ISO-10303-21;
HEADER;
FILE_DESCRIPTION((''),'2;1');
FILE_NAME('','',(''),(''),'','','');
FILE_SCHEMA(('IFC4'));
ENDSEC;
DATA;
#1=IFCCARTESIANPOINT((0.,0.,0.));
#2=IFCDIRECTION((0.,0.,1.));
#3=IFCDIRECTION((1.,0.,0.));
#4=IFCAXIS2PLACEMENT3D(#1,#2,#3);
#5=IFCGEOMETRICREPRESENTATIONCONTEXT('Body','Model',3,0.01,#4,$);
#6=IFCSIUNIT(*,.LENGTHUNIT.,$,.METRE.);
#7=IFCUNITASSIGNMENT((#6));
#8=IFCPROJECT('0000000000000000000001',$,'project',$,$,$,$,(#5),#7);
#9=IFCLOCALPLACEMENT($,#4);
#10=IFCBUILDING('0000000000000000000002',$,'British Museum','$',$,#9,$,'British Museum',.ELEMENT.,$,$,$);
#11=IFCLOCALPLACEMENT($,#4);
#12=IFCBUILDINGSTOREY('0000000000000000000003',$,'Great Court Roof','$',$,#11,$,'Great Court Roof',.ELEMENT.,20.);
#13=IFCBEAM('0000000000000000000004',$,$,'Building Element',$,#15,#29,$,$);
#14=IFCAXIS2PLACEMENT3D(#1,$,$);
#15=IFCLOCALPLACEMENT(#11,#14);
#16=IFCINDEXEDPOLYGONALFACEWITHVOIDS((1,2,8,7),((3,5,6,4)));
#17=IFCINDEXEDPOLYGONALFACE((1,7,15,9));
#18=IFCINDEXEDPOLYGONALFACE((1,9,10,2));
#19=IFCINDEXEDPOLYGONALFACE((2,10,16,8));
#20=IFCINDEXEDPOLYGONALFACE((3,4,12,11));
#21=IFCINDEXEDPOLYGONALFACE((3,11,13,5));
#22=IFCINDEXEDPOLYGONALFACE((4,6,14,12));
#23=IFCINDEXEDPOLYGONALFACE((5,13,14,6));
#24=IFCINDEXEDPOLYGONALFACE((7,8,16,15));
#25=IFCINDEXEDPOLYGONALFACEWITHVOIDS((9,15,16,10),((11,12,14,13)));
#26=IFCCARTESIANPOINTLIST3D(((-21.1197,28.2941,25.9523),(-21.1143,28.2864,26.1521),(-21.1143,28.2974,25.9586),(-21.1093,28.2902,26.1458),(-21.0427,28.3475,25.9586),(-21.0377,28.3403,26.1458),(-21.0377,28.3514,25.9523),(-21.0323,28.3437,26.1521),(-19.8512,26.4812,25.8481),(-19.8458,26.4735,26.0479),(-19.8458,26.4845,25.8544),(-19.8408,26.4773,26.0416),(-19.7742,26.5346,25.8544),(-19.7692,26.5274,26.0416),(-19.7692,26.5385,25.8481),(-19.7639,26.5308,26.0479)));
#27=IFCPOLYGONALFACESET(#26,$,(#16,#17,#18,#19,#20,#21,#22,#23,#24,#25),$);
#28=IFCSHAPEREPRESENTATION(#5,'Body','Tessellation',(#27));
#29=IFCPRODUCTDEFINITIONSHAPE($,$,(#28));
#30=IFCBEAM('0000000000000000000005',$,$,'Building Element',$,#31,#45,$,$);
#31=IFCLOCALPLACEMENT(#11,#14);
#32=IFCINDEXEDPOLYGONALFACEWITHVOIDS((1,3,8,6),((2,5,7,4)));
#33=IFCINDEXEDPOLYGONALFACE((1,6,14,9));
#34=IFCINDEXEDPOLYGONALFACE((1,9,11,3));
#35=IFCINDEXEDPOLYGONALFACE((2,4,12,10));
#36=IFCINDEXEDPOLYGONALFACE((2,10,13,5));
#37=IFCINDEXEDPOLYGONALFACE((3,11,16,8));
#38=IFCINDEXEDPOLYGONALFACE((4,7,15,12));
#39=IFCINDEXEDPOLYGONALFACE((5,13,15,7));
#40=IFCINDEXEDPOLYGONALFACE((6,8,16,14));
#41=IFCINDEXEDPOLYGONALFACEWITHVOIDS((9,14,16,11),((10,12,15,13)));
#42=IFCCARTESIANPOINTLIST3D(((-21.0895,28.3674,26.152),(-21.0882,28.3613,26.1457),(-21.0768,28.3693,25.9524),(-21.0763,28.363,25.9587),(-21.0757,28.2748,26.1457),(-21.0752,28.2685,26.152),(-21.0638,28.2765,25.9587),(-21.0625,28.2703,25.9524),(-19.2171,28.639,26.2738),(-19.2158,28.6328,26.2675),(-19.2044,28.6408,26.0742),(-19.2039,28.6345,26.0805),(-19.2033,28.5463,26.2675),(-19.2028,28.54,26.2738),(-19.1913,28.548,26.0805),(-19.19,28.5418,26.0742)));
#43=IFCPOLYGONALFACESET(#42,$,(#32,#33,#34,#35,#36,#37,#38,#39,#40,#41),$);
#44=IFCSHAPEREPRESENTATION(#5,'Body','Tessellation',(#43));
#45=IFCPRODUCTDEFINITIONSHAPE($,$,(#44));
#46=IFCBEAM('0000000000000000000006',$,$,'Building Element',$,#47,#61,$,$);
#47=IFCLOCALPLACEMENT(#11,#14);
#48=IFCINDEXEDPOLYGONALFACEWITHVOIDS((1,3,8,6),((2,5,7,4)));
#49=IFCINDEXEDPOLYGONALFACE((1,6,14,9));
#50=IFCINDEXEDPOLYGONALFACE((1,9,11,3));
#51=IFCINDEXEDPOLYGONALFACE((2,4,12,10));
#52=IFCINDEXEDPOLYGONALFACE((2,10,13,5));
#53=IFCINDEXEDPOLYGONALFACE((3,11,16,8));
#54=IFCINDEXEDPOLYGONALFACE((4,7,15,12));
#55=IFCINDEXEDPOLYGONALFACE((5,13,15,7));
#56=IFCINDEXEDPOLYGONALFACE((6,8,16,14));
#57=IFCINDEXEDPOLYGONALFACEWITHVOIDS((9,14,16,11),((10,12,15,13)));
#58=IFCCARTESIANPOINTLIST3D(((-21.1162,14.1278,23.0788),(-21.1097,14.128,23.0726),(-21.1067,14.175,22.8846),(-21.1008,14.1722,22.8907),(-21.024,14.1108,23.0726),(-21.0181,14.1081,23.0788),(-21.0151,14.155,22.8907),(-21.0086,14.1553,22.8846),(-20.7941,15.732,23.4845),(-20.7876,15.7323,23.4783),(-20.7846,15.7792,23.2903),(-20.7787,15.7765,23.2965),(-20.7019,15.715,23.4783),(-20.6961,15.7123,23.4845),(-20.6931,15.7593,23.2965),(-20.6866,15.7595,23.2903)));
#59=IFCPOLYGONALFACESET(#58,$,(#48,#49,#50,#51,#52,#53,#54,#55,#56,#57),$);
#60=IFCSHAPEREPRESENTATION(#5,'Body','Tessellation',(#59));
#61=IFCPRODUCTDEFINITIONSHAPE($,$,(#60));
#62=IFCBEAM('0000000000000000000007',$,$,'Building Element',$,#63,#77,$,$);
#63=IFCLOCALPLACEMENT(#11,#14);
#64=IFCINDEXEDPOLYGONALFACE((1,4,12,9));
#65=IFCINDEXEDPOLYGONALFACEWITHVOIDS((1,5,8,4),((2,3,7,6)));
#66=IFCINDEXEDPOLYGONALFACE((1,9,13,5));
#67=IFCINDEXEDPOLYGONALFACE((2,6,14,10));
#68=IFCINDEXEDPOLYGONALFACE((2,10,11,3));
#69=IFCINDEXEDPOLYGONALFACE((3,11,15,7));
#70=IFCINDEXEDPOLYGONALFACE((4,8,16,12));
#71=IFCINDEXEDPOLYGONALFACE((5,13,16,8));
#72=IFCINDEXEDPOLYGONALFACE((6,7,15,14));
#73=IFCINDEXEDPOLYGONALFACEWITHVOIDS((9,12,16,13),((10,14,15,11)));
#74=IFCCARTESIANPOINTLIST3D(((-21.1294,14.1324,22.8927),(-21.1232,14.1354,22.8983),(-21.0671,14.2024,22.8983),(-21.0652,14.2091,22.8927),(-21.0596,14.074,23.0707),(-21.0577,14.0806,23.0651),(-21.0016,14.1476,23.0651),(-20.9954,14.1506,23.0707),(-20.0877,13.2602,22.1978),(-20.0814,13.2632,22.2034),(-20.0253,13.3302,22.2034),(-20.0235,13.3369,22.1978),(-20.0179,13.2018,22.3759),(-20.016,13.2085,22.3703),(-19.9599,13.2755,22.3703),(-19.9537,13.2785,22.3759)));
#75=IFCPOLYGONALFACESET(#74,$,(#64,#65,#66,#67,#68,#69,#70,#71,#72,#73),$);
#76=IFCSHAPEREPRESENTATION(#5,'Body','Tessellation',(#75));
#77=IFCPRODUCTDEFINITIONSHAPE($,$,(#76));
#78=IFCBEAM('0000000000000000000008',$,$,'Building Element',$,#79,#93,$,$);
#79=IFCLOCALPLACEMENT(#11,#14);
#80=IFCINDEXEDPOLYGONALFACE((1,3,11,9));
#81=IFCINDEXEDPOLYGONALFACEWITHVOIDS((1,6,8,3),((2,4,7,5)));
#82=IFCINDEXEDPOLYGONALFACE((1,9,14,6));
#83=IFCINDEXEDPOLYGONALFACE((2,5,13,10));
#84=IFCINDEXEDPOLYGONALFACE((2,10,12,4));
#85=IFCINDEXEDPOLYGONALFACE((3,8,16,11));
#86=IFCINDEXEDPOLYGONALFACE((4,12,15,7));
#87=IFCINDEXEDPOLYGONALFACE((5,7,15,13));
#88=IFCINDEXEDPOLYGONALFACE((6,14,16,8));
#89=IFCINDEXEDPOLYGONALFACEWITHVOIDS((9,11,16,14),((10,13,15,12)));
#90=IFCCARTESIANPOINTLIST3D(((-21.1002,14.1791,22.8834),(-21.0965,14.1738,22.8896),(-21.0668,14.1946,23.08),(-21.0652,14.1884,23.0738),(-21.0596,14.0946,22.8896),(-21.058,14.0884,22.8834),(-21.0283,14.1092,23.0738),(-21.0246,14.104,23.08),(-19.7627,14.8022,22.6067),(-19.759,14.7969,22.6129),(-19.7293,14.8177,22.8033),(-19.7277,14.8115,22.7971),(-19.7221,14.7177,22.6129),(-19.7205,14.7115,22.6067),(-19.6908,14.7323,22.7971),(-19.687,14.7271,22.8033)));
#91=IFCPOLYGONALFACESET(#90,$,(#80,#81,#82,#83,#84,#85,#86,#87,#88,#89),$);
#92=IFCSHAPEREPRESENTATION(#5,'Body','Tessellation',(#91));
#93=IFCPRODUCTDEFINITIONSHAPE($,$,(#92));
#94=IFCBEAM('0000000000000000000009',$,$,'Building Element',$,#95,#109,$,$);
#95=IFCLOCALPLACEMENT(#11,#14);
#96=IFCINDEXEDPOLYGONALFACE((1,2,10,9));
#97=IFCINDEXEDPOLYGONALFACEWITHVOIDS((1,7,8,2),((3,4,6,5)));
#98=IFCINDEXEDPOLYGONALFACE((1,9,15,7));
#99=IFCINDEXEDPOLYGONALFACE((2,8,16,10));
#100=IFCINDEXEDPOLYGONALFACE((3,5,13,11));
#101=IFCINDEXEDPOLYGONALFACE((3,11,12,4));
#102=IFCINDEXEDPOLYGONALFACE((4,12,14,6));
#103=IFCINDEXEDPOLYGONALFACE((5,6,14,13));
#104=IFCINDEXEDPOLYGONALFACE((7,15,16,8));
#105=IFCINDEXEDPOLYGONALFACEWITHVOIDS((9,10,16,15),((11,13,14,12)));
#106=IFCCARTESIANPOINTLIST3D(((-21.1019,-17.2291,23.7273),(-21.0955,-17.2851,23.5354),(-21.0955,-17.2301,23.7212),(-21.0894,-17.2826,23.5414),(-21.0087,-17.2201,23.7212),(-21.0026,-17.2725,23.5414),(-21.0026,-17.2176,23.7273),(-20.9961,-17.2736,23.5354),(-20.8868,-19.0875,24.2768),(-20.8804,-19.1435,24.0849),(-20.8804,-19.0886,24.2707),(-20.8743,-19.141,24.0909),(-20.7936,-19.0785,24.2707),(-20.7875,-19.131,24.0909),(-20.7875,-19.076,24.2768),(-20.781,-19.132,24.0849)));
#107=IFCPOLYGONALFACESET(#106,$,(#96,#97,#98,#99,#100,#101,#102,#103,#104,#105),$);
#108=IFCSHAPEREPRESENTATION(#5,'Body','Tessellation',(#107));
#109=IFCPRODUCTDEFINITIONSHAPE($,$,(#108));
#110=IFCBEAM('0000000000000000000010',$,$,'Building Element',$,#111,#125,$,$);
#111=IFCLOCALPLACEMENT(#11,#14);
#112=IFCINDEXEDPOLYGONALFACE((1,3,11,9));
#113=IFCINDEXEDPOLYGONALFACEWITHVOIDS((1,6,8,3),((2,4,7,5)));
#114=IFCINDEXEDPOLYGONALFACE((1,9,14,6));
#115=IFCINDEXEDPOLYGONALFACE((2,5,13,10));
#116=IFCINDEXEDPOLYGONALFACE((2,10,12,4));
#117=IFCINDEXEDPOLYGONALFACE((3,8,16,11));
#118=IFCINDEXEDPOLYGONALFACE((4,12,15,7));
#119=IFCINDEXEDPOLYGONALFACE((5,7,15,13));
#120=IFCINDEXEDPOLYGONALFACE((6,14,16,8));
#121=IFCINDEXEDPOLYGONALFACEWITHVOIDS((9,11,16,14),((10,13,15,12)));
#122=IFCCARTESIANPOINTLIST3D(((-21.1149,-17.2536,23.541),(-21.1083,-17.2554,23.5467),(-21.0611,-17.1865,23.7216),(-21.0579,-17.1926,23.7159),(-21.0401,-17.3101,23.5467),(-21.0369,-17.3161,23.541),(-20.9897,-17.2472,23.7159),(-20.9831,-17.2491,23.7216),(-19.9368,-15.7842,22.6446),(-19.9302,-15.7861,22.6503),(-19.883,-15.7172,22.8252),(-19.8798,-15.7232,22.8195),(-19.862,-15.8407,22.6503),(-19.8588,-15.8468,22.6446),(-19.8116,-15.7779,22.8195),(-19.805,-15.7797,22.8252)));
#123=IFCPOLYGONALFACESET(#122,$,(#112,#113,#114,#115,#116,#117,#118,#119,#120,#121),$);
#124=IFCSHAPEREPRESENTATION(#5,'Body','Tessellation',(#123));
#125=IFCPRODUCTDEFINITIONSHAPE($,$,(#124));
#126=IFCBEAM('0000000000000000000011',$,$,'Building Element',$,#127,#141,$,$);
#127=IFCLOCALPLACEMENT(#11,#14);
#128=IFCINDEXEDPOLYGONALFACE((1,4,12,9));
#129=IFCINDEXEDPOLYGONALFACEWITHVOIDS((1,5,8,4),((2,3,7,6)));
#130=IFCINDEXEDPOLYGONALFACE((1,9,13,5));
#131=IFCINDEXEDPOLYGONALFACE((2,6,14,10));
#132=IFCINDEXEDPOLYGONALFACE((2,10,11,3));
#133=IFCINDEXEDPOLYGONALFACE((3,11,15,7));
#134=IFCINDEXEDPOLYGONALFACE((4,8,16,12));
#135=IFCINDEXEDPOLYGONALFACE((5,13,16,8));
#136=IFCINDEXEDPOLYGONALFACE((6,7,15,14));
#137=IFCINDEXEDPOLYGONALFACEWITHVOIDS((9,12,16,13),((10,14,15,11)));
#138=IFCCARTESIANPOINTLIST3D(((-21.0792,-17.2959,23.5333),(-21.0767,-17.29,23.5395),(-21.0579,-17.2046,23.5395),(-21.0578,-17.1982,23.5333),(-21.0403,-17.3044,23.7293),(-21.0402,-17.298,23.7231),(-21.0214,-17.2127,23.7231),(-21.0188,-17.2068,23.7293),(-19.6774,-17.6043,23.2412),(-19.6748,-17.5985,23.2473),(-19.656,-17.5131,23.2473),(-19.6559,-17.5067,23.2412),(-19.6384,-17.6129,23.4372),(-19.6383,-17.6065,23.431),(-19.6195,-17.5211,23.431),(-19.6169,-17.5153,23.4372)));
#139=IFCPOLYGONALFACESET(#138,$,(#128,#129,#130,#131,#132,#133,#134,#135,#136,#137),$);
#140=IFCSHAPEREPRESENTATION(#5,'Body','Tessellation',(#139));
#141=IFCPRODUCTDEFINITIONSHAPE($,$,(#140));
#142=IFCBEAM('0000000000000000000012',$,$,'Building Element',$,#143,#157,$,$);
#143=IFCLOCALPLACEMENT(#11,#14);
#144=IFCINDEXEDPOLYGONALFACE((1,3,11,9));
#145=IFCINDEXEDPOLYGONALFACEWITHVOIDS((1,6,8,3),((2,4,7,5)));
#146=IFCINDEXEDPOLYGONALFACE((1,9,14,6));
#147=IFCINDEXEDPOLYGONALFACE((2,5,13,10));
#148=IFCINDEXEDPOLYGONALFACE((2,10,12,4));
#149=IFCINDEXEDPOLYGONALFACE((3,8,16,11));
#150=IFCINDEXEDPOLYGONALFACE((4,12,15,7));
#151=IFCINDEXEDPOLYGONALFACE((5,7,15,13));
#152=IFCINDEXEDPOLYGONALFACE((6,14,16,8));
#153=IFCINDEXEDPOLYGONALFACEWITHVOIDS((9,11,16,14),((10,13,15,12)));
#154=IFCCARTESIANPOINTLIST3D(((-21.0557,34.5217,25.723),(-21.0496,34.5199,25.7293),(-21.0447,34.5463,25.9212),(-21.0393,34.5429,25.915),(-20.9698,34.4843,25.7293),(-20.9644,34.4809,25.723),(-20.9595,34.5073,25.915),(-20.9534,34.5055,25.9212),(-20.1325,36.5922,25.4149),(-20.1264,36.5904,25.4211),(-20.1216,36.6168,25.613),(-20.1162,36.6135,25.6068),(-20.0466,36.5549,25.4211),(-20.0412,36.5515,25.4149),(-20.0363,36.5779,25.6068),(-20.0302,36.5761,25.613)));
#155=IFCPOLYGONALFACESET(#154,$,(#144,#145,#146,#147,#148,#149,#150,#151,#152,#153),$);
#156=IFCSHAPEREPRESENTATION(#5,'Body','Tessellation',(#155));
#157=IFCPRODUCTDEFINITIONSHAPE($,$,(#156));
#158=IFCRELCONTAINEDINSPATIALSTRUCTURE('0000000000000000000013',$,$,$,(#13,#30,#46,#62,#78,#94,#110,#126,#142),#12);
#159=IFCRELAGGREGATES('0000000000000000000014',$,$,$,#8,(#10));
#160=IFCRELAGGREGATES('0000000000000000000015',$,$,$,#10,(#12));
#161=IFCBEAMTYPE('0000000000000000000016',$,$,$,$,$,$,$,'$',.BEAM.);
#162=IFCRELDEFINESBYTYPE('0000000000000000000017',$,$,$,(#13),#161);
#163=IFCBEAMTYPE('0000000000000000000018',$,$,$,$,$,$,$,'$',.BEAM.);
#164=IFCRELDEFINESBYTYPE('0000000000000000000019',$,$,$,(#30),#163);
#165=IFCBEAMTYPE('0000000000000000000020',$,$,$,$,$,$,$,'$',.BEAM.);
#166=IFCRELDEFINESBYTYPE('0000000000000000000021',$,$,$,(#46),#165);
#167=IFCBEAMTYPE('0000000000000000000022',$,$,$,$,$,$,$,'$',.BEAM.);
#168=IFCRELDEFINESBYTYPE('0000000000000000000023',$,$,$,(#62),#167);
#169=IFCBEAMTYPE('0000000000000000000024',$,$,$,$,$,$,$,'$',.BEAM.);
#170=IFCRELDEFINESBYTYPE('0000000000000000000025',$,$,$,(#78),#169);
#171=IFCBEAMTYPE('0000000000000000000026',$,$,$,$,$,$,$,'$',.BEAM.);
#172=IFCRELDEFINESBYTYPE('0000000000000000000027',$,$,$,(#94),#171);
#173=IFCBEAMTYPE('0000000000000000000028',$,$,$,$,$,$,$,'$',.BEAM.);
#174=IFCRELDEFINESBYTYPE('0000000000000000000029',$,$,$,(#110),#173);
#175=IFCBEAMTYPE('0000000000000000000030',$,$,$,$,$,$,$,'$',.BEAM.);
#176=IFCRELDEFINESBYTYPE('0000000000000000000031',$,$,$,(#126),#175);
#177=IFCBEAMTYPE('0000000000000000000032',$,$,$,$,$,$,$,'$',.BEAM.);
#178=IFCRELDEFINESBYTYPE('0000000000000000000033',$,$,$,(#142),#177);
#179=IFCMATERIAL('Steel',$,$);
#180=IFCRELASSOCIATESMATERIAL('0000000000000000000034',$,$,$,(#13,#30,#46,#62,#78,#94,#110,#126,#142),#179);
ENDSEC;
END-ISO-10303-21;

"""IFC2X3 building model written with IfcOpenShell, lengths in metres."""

from ifc_helpers import new_model, si_unit, frame, origin_with_axes, origin_2d, place, context, project, spatial, hollow_rectangle, extrude, material, type_object, element, save


model = new_model("IFC2X3")

# Units and contexts
model_context = context("Model", 3, precision=0.01, world=origin_with_axes(), identifier="Body")
ifc_project = project(units=[si_unit("LENGTHUNIT", "METRE")], contexts=[model_context])

# Building, storey
building_placement = place(None, origin_with_axes())
building = spatial("IfcBuilding", under=ifc_project, at=building_placement, Name="British Museum", Description="$", LongName="British Museum", CompositionType="ELEMENT")
storey_placement = place(None, origin_with_axes())
storey = spatial("IfcBuildingStorey", under=building, at=storey_placement, Name="Great Court Roof", Description="$", LongName="Great Court Roof", CompositionType="ELEMENT", Elevation=20.0)

# Beams
ifc_material = material(Name="Steel")
beam_type_1 = type_object("IfcBeamType", ElementType="$", PredefinedType="BEAM")
beam_1_placement = place(None, origin_with_axes())
element("IfcBeam", 1, at=beam_1_placement, inside=storey, type_object=beam_type_1, material=ifc_material, Description="Building Element", context=model_context, shape_type="SweptSolid", body=[
    extrude(hollow_rectangle(XDim=0.1, YDim=0.2, WallThickness=0.0063, InnerFilletRadius=0.0, OuterFilletRadius=0.0, at=origin_2d()), frame((-21.076, 28.3189, 26.0522), z_axis=(0.572659, -0.818443, -0.047046), x_axis=(0.81935, 0.573294, 0.0)), (0.0, 0.0, 1.0), 2.2151),
])
beam_type_2 = type_object("IfcBeamType", ElementType="$", PredefinedType="BEAM")
beam_2_placement = place(None, origin_with_axes())
element("IfcBeam", 2, at=beam_2_placement, inside=storey, type_object=beam_type_2, material=ifc_material, Description="Building Element", context=model_context, shape_type="SweptSolid", body=[
    extrude(hollow_rectangle(XDim=0.1, YDim=0.2, WallThickness=0.0063, InnerFilletRadius=0.0, OuterFilletRadius=0.0, at=origin_2d()), frame((-21.076, 28.3189, 26.0522), z_axis=(0.987603, 0.143218, 0.064257), x_axis=(-0.143514, 0.989648, 0.0)), (0.0, 0.0, 1.0), 1.8959),
])
beam_type_3 = type_object("IfcBeamType", ElementType="$", PredefinedType="BEAM")
beam_3_placement = place(None, origin_with_axes())
element("IfcBeam", 3, at=beam_3_placement, inside=storey, type_object=beam_type_3, material=ifc_material, Description="Building Element", context=model_context, shape_type="SweptSolid", body=[
    extrude(hollow_rectangle(XDim=0.1, YDim=0.2, WallThickness=0.0063, InnerFilletRadius=0.0, OuterFilletRadius=0.0, at=origin_2d()), frame((-21.0624, 14.1415, 22.9817), z_axis=(0.191047, 0.951621, 0.240663), x_axis=(-0.980437, 0.196832, 0.0)), (0.0, 0.0, 1.0), 1.6858),
])
beam_type_4 = type_object("IfcBeamType", ElementType="$", PredefinedType="BEAM")
beam_4_placement = place(None, origin_with_axes())
element("IfcBeam", 4, at=beam_4_placement, inside=storey, type_object=beam_type_4, material=ifc_material, Description="Building Element", context=model_context, shape_type="SweptSolid", body=[
    extrude(hollow_rectangle(XDim=0.1, YDim=0.2, WallThickness=0.0063, InnerFilletRadius=0.0, OuterFilletRadius=0.0, at=origin_2d()), frame((-21.0624, 14.1415, 22.9817), z_axis=(0.68265, -0.571546, -0.455329), x_axis=(0.641953, 0.766744, 0.0)), (0.0, 0.0, 1.0), 1.526),
])
beam_type_5 = type_object("IfcBeamType", ElementType="$", PredefinedType="BEAM")
beam_5_placement = place(None, origin_with_axes())
element("IfcBeam", 5, at=beam_5_placement, inside=storey, type_object=beam_type_5, material=ifc_material, Description="Building Element", context=model_context, shape_type="SweptSolid", body=[
    extrude(hollow_rectangle(XDim=0.1, YDim=0.2, WallThickness=0.0063, InnerFilletRadius=0.0, OuterFilletRadius=0.0, at=origin_2d()), frame((-21.0624, 14.1415, 22.9817), z_axis=(0.890936, 0.415048, -0.184306), x_axis=(-0.422282, 0.906464, 0.0)), (0.0, 0.0, 1.0), 1.5013),
])
beam_type_6 = type_object("IfcBeamType", ElementType="$", PredefinedType="BEAM")
beam_6_placement = place(None, origin_with_axes())
element("IfcBeam", 6, at=beam_6_placement, inside=storey, type_object=beam_type_6, material=ifc_material, Description="Building Element", context=model_context, shape_type="SweptSolid", body=[
    extrude(hollow_rectangle(XDim=0.1, YDim=0.2, WallThickness=0.0063, InnerFilletRadius=0.0, OuterFilletRadius=0.0, at=origin_2d()), frame((-21.049, -17.2513, 23.6313), z_axis=(0.11031, -0.953106, 0.281815), x_axis=(0.993369, 0.11497, 0.0)), (0.0, 0.0, 1.0), 1.9499),
])
beam_type_7 = type_object("IfcBeamType", ElementType="$", PredefinedType="BEAM")
beam_7_placement = place(None, origin_with_axes())
element("IfcBeam", 7, at=beam_7_placement, inside=storey, type_object=beam_type_7, material=ifc_material, Description="Building Element", context=model_context, shape_type="SweptSolid", body=[
    extrude(hollow_rectangle(XDim=0.1, YDim=0.2, WallThickness=0.0063, InnerFilletRadius=0.0, OuterFilletRadius=0.0, at=origin_2d()), frame((-21.049, -17.2513, 23.6313), z_axis=(0.564836, 0.704457, -0.429769), x_axis=(-0.780182, 0.625553, 0.0)), (0.0, 0.0, 1.0), 2.0858),
])
beam_type_8 = type_object("IfcBeamType", ElementType="$", PredefinedType="BEAM")
beam_8_placement = place(None, origin_with_axes())
element("IfcBeam", 8, at=beam_8_placement, inside=storey, type_object=beam_type_8, material=ifc_material, Description="Building Element", context=model_context, shape_type="SweptSolid", body=[
    extrude(hollow_rectangle(XDim=0.1, YDim=0.2, WallThickness=0.0063, InnerFilletRadius=0.0, OuterFilletRadius=0.0, at=origin_2d()), frame((-21.049, -17.2513, 23.6313), z_axis=(0.957013, -0.210589, -0.199446), x_axis=(0.214907, 0.976635, 0.0)), (0.0, 0.0, 1.0), 1.4648),
])
beam_type_9 = type_object("IfcBeamType", ElementType="$", PredefinedType="BEAM")
beam_9_placement = place(None, origin_with_axes())
element("IfcBeam", 9, at=beam_9_placement, inside=storey, type_object=beam_type_9, material=ifc_material, Description="Building Element", context=model_context, shape_type="SweptSolid", body=[
    extrude(hollow_rectangle(XDim=0.1, YDim=0.2, WallThickness=0.0063, InnerFilletRadius=0.0, OuterFilletRadius=0.0, at=origin_2d()), frame((-21.0046, 34.5136, 25.8221), z_axis=(0.403501, 0.905011, -0.134691), x_axis=(-0.913334, 0.407211, 0.0)), (0.0, 0.0, 1.0), 2.2879),
])

save(model, "model.ifc")
